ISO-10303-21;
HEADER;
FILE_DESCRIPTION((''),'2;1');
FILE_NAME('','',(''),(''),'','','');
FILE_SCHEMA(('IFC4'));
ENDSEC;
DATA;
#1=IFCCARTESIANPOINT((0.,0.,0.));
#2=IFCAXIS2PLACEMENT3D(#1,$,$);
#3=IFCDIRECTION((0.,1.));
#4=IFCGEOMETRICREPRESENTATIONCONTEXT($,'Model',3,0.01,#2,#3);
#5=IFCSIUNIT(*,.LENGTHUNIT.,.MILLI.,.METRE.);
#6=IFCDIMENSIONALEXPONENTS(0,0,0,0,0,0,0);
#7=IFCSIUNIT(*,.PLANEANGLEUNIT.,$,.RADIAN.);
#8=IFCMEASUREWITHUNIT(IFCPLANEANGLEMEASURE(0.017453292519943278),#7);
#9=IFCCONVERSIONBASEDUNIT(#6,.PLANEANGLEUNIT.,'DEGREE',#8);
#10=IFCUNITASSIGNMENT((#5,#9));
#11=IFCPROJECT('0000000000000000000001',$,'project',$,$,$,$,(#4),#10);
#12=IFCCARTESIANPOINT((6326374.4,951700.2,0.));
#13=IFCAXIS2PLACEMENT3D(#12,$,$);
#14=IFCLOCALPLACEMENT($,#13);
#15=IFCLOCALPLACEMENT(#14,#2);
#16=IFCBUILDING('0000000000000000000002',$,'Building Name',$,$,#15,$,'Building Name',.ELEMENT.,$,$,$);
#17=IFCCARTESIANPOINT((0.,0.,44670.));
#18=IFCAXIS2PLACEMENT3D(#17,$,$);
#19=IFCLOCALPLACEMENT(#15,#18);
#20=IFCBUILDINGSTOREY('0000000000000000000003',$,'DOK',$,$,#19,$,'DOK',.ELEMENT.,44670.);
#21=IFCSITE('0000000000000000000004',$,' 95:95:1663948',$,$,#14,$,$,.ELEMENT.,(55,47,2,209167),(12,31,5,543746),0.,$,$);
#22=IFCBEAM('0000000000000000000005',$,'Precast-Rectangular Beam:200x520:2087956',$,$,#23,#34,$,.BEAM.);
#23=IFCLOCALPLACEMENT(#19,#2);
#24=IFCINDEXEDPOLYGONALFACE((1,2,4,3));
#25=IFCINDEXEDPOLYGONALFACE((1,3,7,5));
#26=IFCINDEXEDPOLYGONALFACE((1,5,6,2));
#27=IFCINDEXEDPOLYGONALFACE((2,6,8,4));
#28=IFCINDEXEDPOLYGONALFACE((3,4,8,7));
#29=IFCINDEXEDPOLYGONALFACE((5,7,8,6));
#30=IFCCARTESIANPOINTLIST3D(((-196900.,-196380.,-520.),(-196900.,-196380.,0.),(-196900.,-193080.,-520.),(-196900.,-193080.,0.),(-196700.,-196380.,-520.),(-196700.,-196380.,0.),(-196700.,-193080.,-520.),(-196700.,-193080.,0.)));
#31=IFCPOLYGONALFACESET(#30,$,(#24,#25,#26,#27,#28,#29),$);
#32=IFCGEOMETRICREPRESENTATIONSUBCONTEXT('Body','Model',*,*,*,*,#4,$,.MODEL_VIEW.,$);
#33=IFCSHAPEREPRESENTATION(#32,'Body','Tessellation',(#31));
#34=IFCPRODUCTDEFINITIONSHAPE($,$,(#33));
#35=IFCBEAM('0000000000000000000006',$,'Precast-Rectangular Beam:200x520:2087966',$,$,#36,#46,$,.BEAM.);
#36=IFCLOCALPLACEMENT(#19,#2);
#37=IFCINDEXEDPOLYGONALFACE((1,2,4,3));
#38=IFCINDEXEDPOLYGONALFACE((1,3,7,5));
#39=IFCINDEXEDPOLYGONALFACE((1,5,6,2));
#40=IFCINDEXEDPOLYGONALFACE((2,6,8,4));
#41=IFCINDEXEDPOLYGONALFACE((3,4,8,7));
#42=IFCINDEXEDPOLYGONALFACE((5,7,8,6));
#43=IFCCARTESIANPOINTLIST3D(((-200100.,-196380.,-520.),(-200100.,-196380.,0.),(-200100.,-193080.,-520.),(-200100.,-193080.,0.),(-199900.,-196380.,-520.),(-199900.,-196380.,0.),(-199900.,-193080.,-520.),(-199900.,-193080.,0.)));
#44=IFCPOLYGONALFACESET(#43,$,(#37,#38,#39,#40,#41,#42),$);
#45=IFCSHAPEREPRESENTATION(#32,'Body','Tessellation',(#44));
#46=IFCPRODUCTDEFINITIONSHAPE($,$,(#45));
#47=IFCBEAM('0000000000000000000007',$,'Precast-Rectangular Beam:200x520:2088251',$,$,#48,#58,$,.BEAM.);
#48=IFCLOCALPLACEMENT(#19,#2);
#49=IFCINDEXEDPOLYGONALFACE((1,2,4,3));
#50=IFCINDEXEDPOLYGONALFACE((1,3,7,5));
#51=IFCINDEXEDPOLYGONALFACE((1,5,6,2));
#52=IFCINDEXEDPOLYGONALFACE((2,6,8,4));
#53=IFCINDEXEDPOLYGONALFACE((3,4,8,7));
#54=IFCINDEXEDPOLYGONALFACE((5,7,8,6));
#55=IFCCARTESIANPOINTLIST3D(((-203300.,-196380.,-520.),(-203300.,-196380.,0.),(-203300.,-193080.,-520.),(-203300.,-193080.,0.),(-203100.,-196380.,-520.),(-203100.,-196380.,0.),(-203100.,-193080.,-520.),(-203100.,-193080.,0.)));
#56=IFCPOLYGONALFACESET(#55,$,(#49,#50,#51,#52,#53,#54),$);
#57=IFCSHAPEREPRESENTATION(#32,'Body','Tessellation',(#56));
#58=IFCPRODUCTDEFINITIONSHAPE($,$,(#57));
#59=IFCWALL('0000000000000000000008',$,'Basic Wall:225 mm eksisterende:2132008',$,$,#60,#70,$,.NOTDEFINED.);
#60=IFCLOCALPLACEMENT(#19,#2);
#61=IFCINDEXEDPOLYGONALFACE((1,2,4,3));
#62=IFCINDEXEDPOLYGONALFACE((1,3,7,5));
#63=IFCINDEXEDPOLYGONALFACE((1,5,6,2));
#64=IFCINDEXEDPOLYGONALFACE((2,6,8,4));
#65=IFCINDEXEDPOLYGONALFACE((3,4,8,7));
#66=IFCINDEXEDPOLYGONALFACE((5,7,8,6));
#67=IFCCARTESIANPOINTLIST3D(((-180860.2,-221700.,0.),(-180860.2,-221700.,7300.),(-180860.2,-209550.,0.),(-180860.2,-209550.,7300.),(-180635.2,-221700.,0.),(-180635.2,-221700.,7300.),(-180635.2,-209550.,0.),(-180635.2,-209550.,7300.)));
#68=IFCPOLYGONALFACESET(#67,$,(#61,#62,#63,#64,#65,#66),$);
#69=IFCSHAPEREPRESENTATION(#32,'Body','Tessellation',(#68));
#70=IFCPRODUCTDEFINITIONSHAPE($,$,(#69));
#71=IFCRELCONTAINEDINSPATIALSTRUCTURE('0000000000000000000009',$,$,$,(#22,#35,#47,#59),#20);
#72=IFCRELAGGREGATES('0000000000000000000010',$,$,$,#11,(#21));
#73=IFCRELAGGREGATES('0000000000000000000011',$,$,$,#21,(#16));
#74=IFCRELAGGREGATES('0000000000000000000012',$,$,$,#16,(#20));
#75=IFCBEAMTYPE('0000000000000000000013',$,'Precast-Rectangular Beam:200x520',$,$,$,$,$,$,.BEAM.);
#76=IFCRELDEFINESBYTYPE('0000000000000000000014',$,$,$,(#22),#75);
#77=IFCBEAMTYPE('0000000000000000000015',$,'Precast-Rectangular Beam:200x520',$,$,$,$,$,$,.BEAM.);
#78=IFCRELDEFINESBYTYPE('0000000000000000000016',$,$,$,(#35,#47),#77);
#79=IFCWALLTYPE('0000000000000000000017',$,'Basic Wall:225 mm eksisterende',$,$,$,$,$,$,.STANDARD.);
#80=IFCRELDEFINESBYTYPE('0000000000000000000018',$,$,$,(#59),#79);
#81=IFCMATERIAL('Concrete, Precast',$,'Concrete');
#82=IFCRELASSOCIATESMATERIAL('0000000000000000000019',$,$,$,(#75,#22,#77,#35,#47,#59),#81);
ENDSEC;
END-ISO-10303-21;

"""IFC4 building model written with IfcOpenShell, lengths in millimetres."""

from ifc_helpers import new_model, entity, si_unit, converted_unit, direction, frame, origin, place, context, subcontext, project, spatial, indexed_curve, outline, extrude, source, transform, mapped, material, type_object, type_shapes, element, save


model = new_model("IFC4")

# Units and contexts
model_context = context("Model", 3, precision=0.01, world=origin(), true_north=direction((0.0, 1.0)))
body_context = subcontext(model_context, "Body", "Model", "MODEL_VIEW")
ifc_project = project(units=[si_unit("LENGTHUNIT", "METRE", prefix="MILLI"), converted_unit("PLANEANGLEUNIT", "DEGREE", entity("IfcPlaneAngleMeasure", 0.017453292519943278), si_unit("PLANEANGLEUNIT", "RADIAN"), dimensions=[0, 0, 0, 0, 0, 0, 0])], contexts=[model_context])

# Site, building, storey
site_placement = place(None, frame((6326374.4, 951700.2, 0.0)))
site = spatial("IfcSite", under=ifc_project, at=site_placement, Name=" 95:95:1663948", CompositionType="ELEMENT", RefLatitude=(55, 47, 2, 209167), RefLongitude=(12, 31, 5, 543746), RefElevation=0.0)
building_placement = place(site_placement, origin())
building = spatial("IfcBuilding", under=site, at=building_placement, Name="Building Name", LongName="Building Name", CompositionType="ELEMENT")
storey_placement = place(building_placement, frame((0.0, 0.0, 44670.0)))
storey = spatial("IfcBuildingStorey", under=building, at=storey_placement, Name="DOK", LongName="DOK", CompositionType="ELEMENT", Elevation=44670.0)

# Beams
ifc_material = material(Name="Concrete, Precast", Category="Concrete")
beam_type_1 = type_object("IfcBeamType", Name="Precast-Rectangular Beam:200x520", PredefinedType="BEAM", material=ifc_material)
shared_shape_1 = source(origin(), body_context, "Body", "SweptSolid", [
    extrude(outline(indexed_curve([(-1650.0, -100.0), (1650.0, -100.0), (1650.0, 100.0), (-1650.0, 100.0), (-1650.0, -100.0)], self_intersect=False)), frame((100.0, 0.0, -260.0), z_axis=(0.0, 0.0, 1.0), x_axis=(-1.0, 0.0, 0.0)), (0.0, 0.0, 1.0), 520.0),
])
type_shapes(beam_type_1, [shared_shape_1])
beam_1_placement = place(storey_placement, frame((-196800.0, -194630.0, -260.0), z_axis=(0.0, 0.0, 1.0), x_axis=(0.0, -1.0, 0.0)))
element("IfcBeam", 1, at=beam_1_placement, inside=storey, type_object=beam_type_1, material=ifc_material, Name="Precast-Rectangular Beam:200x520:2087956", PredefinedType="BEAM", context=body_context, shape_type="MappedRepresentation", body=[
    mapped(shared_shape_1, transform((0.0, 0.0, 0.0), scale=1.0)),
])
beam_type_2 = type_object("IfcBeamType", Name="Precast-Rectangular Beam:200x520", PredefinedType="BEAM", material=ifc_material)
shared_shape_2 = source(origin(), body_context, "Body", "SweptSolid", [
    extrude(outline(indexed_curve([(-1650.0, -100.0), (1650.0, -100.0), (1650.0, 100.0), (-1650.0, 100.0), (-1650.0, -100.0)], self_intersect=False)), frame((100.0, 0.0, -260.0), z_axis=(0.0, 0.0, 1.0), x_axis=(-1.0, 0.0, 0.0)), (0.0, 0.0, 1.0), 520.0),
])
type_shapes(beam_type_2, [shared_shape_2])
for number, where, z_axis, x_axis, name in (
    (2, (-200000.0, -194630.0, -260.0), (0.0, 0.0, 1.0), (0.0, -1.0, 0.0), "Precast-Rectangular Beam:200x520:2087966"),
    (3, (-203200.0, -194630.0, -260.0), (0.0, 0.0, 1.0), (0.0, -1.0, 0.0), "Precast-Rectangular Beam:200x520:2088251"),
):
    element("IfcBeam", number, at=place(storey_placement, frame(where, z_axis=z_axis, x_axis=x_axis)), inside=storey, type_object=beam_type_2, material=ifc_material, Name=name, PredefinedType="BEAM", context=body_context, shape_type="MappedRepresentation", body=[
        mapped(shared_shape_2, transform((0.0, 0.0, 0.0), scale=1.0)),
    ])

# Wall
wall_type = type_object("IfcWallType", Name="Basic Wall:225 mm eksisterende", PredefinedType="STANDARD")
wall_placement = place(storey_placement, frame((-180747.7, -209550.0, 0.0), z_axis=(0.0, 0.0, 1.0), x_axis=(0.0, -1.0, 0.0)))
element("IfcWall", 4, at=wall_placement, inside=storey, type_object=wall_type, material=ifc_material, Name="Basic Wall:225 mm eksisterende:2132008", PredefinedType="NOTDEFINED", context=body_context, shape_type="SweptSolid", body=[
    extrude(outline(indexed_curve([(12150.0, 112.5), (0.0, 112.5), (0.0, -112.5), (12150.0, -112.5), (12150.0, 112.5)], self_intersect=False)), origin(), (0.0, 0.0, 1.0), 7300.0),
])

save(model, "model.ifc")
